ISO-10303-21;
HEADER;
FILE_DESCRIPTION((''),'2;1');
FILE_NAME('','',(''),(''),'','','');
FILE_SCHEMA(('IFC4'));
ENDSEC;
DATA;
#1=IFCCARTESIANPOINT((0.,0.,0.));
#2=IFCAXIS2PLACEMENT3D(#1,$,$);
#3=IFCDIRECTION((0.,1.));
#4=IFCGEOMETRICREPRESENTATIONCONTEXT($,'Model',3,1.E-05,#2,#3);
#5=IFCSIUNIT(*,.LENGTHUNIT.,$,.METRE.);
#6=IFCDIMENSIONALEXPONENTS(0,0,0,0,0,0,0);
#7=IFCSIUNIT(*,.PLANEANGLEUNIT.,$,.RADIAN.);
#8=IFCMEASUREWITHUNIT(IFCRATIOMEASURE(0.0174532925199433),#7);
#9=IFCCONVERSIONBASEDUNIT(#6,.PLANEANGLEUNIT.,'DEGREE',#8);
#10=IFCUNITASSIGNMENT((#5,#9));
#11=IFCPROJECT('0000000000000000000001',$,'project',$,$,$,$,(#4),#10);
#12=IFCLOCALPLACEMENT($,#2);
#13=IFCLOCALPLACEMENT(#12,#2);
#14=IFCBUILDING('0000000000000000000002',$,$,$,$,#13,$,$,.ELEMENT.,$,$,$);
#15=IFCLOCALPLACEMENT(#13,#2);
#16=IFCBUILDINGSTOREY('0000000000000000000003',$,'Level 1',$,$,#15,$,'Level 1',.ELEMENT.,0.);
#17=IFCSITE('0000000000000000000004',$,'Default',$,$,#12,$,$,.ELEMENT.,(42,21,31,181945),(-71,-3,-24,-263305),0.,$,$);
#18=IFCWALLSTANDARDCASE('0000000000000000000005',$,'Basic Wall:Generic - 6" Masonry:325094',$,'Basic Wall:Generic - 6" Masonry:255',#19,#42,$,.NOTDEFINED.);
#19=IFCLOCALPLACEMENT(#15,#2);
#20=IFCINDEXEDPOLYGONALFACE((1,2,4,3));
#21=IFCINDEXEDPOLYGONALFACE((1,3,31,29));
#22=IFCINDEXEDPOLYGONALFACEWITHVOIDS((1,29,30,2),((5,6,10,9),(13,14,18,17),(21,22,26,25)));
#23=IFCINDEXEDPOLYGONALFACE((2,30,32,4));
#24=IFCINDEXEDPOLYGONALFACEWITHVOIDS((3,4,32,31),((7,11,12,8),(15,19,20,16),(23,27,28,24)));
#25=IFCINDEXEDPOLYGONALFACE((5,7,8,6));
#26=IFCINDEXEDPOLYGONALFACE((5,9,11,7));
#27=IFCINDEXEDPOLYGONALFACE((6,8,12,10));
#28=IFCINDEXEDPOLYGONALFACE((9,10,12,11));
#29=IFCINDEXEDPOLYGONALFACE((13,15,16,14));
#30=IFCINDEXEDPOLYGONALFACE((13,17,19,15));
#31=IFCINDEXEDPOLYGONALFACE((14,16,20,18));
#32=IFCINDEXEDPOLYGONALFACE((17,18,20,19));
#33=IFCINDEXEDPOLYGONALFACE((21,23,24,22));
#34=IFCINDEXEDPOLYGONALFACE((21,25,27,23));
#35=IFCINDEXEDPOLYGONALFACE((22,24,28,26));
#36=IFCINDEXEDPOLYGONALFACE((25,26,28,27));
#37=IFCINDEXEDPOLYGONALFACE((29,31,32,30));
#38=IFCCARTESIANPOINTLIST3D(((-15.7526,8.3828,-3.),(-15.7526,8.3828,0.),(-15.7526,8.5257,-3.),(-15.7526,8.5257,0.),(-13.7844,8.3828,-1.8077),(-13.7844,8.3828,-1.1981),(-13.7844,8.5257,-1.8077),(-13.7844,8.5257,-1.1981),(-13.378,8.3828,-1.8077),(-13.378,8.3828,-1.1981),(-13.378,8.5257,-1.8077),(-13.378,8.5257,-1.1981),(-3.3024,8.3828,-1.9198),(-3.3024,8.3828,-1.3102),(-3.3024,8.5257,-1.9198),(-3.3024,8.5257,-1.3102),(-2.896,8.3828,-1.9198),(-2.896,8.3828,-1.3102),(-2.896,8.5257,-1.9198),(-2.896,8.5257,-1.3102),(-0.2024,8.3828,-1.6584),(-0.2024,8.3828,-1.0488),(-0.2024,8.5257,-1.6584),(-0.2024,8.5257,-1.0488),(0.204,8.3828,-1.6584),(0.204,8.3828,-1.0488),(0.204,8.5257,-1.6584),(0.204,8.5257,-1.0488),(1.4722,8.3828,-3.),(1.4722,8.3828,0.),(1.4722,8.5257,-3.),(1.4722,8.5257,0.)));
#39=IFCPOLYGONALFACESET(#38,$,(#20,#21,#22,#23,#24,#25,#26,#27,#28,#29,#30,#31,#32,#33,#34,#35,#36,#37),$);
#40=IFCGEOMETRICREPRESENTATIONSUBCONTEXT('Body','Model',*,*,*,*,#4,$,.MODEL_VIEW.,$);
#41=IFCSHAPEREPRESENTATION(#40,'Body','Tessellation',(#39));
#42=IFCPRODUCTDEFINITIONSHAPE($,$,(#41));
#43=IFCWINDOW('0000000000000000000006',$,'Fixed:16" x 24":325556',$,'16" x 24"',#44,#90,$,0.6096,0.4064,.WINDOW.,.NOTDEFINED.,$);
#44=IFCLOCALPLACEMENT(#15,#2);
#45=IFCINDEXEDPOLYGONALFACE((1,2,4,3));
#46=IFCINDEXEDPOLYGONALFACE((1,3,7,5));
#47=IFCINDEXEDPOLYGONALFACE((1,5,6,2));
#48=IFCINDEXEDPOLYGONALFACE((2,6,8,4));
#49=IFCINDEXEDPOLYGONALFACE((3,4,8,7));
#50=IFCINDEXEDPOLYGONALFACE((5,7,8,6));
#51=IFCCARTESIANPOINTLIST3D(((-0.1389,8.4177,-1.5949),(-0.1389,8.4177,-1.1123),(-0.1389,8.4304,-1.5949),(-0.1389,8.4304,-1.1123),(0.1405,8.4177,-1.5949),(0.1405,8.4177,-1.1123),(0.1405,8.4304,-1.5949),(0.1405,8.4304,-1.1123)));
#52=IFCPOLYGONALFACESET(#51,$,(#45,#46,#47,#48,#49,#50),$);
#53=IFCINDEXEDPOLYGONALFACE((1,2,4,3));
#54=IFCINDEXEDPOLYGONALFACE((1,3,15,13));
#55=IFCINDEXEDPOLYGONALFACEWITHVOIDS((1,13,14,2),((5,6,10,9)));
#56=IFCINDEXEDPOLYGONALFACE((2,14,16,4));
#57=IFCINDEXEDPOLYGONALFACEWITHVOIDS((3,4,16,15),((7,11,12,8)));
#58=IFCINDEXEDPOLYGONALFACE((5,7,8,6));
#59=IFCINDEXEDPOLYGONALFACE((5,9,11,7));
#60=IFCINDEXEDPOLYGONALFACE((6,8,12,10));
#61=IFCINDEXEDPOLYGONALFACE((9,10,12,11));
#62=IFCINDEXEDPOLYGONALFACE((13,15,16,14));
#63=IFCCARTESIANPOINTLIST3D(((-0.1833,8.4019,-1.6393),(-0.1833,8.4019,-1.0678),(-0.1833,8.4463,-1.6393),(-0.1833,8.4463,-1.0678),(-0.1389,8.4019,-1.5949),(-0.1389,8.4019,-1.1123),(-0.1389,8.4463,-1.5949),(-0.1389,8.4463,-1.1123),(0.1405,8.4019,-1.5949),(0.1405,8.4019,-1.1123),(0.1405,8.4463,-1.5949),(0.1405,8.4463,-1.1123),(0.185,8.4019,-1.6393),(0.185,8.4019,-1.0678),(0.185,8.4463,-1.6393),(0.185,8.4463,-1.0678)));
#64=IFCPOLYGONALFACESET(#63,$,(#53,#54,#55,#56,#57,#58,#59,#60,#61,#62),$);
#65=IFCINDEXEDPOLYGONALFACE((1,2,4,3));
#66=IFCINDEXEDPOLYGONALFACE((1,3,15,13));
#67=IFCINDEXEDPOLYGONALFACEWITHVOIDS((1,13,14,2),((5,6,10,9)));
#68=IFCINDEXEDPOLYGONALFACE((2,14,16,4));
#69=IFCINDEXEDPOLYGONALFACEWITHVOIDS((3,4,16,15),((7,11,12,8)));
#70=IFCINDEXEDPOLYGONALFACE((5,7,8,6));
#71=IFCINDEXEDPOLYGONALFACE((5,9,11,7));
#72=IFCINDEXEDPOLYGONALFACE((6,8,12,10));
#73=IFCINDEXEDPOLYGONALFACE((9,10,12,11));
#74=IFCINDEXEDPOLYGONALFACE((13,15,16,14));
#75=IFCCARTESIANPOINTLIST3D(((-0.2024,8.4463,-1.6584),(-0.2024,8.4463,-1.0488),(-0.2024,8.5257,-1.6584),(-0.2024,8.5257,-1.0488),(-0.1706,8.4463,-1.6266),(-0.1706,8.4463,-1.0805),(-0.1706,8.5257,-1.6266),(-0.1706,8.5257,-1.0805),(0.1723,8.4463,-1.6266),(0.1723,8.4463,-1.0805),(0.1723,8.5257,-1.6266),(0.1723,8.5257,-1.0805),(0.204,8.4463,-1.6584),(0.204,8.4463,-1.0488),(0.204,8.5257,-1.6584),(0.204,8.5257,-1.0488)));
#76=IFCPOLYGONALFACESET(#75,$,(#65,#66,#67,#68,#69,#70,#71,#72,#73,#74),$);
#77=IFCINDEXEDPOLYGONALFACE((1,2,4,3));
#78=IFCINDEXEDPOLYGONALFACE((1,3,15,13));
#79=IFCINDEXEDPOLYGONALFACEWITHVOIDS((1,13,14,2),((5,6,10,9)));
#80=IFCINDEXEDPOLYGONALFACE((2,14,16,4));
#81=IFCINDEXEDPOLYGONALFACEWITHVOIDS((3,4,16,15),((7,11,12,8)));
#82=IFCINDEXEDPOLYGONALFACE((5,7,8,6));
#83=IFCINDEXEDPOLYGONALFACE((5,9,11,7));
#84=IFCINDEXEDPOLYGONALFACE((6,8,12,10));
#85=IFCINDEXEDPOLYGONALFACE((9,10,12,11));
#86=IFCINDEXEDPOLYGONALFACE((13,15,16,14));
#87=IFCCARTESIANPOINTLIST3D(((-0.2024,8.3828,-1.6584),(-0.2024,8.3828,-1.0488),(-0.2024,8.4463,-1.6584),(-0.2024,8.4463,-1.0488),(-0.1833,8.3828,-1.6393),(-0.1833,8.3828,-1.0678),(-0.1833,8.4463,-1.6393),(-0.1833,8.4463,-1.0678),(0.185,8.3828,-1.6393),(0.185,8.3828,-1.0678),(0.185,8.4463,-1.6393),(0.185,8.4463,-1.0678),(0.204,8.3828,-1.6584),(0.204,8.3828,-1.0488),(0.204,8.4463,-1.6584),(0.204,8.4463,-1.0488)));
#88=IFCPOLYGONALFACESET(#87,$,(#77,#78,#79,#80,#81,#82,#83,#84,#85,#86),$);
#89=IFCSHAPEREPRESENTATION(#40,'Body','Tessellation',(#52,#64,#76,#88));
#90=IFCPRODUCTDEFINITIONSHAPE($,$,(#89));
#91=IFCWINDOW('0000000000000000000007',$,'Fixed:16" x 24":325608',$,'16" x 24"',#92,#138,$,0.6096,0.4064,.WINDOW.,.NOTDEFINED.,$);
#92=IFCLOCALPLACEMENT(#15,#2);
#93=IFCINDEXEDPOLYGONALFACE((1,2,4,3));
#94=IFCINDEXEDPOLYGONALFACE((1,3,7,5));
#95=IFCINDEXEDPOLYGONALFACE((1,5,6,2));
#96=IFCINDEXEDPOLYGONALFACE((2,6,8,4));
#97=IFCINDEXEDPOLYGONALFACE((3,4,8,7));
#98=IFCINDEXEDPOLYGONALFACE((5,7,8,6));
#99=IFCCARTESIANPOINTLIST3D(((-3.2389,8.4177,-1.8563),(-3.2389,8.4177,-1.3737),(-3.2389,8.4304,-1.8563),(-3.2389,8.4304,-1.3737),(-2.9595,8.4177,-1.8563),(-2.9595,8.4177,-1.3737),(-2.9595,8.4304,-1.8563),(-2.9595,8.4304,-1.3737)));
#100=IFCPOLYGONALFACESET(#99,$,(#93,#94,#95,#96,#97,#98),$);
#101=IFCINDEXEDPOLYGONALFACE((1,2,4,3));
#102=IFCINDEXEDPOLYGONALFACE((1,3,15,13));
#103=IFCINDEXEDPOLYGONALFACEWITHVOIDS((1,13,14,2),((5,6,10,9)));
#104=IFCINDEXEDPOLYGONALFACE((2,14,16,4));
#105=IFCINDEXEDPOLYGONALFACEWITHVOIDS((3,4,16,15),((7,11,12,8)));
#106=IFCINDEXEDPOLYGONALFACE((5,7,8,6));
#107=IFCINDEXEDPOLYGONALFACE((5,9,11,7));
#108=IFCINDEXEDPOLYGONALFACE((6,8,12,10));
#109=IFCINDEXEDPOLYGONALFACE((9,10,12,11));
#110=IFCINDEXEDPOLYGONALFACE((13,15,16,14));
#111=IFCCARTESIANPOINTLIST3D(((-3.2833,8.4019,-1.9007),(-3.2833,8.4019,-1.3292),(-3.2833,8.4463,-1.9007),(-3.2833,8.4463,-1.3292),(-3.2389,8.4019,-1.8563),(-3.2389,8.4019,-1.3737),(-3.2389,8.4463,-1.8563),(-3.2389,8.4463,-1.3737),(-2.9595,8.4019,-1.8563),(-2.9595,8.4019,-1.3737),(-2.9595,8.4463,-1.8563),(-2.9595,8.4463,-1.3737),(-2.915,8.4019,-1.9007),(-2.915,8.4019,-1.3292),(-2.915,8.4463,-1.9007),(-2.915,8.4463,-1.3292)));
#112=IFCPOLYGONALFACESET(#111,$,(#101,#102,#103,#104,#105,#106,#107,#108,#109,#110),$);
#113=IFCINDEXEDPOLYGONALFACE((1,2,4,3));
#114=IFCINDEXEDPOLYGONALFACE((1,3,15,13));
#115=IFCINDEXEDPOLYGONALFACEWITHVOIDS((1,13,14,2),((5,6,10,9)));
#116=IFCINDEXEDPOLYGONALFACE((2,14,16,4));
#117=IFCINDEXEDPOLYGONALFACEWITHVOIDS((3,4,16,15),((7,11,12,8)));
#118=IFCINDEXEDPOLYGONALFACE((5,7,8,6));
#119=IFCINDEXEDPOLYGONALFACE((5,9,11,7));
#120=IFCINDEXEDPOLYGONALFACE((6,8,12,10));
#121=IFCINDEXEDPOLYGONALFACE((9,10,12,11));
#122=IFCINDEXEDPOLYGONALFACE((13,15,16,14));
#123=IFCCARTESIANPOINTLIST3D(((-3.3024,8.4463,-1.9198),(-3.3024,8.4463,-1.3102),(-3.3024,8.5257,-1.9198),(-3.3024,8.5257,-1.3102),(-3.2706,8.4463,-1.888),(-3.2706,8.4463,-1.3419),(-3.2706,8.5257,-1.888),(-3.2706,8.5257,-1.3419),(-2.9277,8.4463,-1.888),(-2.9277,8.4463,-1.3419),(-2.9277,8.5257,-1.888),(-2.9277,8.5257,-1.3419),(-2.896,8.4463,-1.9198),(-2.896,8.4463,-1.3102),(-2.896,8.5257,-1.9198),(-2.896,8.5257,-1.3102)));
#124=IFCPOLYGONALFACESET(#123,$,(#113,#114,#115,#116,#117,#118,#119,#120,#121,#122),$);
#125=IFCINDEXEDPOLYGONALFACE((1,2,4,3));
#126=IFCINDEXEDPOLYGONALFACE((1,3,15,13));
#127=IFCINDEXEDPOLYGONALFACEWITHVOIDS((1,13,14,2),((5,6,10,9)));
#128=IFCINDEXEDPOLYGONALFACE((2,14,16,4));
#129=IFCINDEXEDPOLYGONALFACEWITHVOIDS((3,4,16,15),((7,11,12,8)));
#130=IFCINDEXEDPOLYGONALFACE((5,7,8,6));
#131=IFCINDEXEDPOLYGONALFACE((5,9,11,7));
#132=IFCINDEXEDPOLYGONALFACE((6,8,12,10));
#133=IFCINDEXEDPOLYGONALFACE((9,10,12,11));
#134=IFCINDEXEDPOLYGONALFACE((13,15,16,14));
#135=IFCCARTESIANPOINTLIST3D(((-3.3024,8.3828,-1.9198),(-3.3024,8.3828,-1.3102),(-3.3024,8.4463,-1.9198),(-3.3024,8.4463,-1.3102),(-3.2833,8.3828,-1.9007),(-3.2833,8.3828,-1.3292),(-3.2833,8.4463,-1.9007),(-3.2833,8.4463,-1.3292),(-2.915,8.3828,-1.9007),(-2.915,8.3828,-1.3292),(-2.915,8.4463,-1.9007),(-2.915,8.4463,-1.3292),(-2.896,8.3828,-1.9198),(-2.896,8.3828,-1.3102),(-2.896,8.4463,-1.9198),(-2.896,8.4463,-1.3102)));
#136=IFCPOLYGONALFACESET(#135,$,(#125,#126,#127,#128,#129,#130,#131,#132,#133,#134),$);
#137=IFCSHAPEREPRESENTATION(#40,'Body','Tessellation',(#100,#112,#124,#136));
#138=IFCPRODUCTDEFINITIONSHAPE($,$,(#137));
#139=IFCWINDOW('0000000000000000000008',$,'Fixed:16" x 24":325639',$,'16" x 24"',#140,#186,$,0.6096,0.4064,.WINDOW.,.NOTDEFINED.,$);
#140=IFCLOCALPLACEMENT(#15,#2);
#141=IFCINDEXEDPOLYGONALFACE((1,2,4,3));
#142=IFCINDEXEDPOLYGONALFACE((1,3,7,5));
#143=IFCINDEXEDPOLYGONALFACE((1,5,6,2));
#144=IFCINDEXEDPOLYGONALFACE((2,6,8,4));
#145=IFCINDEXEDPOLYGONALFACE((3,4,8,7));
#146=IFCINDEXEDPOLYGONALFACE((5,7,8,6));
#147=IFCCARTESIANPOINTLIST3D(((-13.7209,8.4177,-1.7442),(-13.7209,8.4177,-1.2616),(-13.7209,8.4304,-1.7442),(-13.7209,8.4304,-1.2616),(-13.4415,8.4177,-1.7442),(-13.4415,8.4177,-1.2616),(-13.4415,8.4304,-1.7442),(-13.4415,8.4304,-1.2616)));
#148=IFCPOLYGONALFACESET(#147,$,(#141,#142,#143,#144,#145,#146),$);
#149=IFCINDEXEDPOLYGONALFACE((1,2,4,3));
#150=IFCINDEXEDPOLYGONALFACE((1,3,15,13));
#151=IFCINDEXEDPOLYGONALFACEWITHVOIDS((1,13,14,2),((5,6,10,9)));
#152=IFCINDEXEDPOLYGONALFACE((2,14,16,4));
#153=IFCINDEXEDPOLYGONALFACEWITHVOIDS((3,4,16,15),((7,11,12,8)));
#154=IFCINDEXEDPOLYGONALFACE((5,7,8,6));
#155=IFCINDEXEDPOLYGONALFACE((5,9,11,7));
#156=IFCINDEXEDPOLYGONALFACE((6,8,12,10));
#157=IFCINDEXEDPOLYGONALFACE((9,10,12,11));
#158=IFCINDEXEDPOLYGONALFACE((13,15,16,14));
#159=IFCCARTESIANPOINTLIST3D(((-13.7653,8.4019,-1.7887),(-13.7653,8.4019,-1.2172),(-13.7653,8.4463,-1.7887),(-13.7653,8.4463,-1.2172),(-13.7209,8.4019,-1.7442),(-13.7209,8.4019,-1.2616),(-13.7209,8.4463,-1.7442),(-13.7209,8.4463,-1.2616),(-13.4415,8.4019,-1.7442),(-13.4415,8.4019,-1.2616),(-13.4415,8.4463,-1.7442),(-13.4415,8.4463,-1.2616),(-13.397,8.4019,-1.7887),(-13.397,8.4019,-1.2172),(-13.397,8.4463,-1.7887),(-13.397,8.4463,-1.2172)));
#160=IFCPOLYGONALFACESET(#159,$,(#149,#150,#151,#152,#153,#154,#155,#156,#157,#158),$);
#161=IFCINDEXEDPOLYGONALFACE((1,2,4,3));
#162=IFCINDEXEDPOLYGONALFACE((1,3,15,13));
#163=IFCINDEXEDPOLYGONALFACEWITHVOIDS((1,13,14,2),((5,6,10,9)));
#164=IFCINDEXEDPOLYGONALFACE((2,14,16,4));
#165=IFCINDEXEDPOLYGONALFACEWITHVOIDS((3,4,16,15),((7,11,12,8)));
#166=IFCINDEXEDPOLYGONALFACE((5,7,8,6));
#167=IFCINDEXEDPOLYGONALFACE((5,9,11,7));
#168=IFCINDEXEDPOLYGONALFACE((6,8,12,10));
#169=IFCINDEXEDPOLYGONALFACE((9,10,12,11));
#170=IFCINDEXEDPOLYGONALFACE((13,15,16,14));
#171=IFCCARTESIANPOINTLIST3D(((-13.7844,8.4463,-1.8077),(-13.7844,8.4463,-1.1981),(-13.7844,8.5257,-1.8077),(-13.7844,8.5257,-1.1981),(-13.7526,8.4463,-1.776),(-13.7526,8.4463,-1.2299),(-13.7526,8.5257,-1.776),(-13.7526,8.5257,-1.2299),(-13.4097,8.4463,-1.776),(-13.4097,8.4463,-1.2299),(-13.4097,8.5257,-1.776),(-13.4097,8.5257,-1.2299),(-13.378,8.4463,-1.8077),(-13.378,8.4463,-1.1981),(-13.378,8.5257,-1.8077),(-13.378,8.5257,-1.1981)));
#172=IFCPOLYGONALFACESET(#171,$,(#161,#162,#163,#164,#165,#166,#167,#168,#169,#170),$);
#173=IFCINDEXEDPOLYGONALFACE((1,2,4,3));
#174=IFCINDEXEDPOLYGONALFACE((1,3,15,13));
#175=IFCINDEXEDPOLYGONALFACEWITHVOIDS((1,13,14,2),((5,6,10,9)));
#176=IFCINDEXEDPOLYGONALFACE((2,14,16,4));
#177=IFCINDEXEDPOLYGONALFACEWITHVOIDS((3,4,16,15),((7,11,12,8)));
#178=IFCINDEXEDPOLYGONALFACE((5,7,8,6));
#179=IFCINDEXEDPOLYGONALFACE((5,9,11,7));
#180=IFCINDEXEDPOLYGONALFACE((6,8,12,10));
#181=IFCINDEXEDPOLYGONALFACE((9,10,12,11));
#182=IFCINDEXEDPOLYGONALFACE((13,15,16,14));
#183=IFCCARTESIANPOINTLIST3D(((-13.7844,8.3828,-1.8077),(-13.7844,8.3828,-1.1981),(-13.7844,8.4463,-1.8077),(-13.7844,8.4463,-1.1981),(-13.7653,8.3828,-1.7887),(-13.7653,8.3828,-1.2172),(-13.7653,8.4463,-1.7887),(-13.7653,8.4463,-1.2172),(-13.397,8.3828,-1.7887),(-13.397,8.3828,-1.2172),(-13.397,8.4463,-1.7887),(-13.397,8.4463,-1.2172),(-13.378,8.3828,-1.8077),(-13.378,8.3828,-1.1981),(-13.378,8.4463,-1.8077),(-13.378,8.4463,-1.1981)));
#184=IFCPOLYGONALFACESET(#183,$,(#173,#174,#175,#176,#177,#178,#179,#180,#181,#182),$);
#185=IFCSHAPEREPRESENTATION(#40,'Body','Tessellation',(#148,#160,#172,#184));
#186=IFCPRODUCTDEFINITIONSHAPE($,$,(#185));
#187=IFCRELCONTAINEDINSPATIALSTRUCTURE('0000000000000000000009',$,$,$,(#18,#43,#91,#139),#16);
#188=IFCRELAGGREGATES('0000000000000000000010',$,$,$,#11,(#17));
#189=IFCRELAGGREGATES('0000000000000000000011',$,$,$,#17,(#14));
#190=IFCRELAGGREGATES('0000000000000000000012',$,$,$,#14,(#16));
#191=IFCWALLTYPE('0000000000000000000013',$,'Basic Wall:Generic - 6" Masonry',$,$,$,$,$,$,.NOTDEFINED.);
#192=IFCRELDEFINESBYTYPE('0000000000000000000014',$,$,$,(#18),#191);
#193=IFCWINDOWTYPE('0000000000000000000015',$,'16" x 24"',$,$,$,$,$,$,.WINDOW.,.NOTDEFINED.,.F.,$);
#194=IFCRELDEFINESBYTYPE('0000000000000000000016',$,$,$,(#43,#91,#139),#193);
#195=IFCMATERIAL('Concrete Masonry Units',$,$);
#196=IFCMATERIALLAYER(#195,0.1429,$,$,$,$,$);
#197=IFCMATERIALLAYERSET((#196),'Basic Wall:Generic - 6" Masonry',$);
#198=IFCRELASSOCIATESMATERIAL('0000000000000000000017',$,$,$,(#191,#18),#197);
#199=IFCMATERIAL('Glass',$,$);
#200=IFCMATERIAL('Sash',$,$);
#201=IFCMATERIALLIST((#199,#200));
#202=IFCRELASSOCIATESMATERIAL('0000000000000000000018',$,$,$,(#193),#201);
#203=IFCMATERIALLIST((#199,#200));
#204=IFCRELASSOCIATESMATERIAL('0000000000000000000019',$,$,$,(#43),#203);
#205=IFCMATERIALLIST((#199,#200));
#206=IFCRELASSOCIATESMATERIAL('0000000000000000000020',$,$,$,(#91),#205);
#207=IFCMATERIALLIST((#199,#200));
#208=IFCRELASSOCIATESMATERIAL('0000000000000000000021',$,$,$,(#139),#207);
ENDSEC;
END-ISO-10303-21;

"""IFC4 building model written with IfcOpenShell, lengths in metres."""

from ifc_helpers import new_model, entity, si_unit, converted_unit, direction, frame, frame_2d, origin, place, context, subcontext, project, spatial, polyline, rectangle, outline, extrude, source, transform, mapped, material, material_list, layer, layer_set, layer_usage, type_object, type_shapes, element, fill, save


model = new_model("IFC4")

# Units and contexts
model_context = context("Model", 3, precision=1e-05, world=origin(), true_north=direction((0.0, 1.0)))
body_context = subcontext(model_context, "Body", "Model", "MODEL_VIEW")
ifc_project = project(units=[si_unit("LENGTHUNIT", "METRE"), converted_unit("PLANEANGLEUNIT", "DEGREE", entity("IfcRatioMeasure", 0.0174532925199433), si_unit("PLANEANGLEUNIT", "RADIAN"), dimensions=[0, 0, 0, 0, 0, 0, 0])], contexts=[model_context])

# Site, building, storey
site_placement = place(None, origin())
site = spatial("IfcSite", under=ifc_project, at=site_placement, Name="Default", CompositionType="ELEMENT", RefLatitude=(42, 21, 31, 181945), RefLongitude=(-71, -3, -24, -263305), RefElevation=0.0)
building_placement = place(site_placement, origin())
building = spatial("IfcBuilding", under=site, at=building_placement, CompositionType="ELEMENT")
storey_placement = place(building_placement, origin())
storey = spatial("IfcBuildingStorey", under=building, at=storey_placement, Name="Level 1", LongName="Level 1", CompositionType="ELEMENT", Elevation=0.0)

# Wall, openings, windows
ifc_material_1 = material(Name="Concrete Masonry Units")
ifc_layer = layer(ifc_material_1, 0.1429)
ifc_layer_set = layer_set([ifc_layer], Name="Basic Wall:Generic - 6\" Masonry")
ifc_layer_usage_1 = layer_usage(ifc_layer_set, "AXIS2", "NEGATIVE", 0.0714)
wall_type = type_object("IfcWallType", Name="Basic Wall:Generic - 6\" Masonry", PredefinedType="NOTDEFINED", material=ifc_layer_set)
wall_1_placement = place(storey_placement, frame((-15.7526, 8.4542, -3.0)))
wall_1 = element("IfcWallStandardCase", 1, at=wall_1_placement, inside=storey, type_object=wall_type, material=ifc_layer_usage_1, Name="Basic Wall:Generic - 6\" Masonry:325094", ObjectType="Basic Wall:Generic - 6\" Masonry:255", PredefinedType="NOTDEFINED", context=body_context, shape_type="SweptSolid", body=[
    extrude(rectangle(XDim=17.2249, YDim=0.1429, at=frame_2d((8.6124, 0.0), x_axis=(-1.0, 0.0))), origin(), (0.0, 0.0, 1.0), 3.0),
])
opening_1_placement = place(wall_1_placement, frame((15.9566, 0.0714, 1.3416)))
opening_1 = element("IfcOpeningElement", 2, at=opening_1_placement, cuts=wall_1, ObjectType="Opening", PredefinedType="OPENING", context=body_context, shape_type="SweptSolid", body=[
    extrude(rectangle(XDim=0.6096, YDim=0.4064, at=frame_2d((0.3048, 0.2032), x_axis=(-1.0, 0.0))), frame((0.0, 0.0, 0.0), z_axis=(0.0, -1.0, 0.0), x_axis=(0.0, 0.0, 1.0)), (0.0, 0.0, 1.0), 0.1429),
])
opening_2_placement = place(wall_1_placement, frame((12.8566, 0.0714, 1.0802)))
opening_2 = element("IfcOpeningElement", 3, at=opening_2_placement, cuts=wall_1, ObjectType="Opening", PredefinedType="OPENING", context=body_context, shape_type="SweptSolid", body=[
    extrude(rectangle(XDim=0.6096, YDim=0.4064, at=frame_2d((0.3048, 0.2032), x_axis=(-1.0, 0.0))), frame((0.0, 0.0, 0.0), z_axis=(0.0, -1.0, 0.0), x_axis=(0.0, 0.0, 1.0)), (0.0, 0.0, 1.0), 0.1429),
])
opening_3_placement = place(wall_1_placement, frame((2.3746, 0.0714, 1.1923)))
opening_3 = element("IfcOpeningElement", 4, at=opening_3_placement, cuts=wall_1, ObjectType="Opening", PredefinedType="OPENING", context=body_context, shape_type="SweptSolid", body=[
    extrude(rectangle(XDim=0.6096, YDim=0.4064, at=frame_2d((0.3048, 0.2032), x_axis=(-1.0, 0.0))), frame((0.0, 0.0, 0.0), z_axis=(0.0, -1.0, 0.0), x_axis=(0.0, 0.0, 1.0)), (0.0, 0.0, 1.0), 0.1429),
])
ifc_material_2 = material(Name="Glass")
ifc_material_3 = material(Name="Sash")
ifc_material_list_1 = material_list([ifc_material_2, ifc_material_3])
ifc_material_list_2 = material_list([ifc_material_2, ifc_material_3])
window_type = type_object("IfcWindowType", Name="16\" x 24\"", ParameterTakesPrecedence=False, PartitioningType="NOTDEFINED", PredefinedType="WINDOW", material=ifc_material_list_2)
shared_shape = source(origin(), body_context, "Body", "SweptSolid", [
    extrude(rectangle(XDim=0.0127, YDim=0.2794, at=frame_2d((0.0, 0.0), x_axis=(1.0, 0.0))), frame((0.2032, 0.1016, 0.0635), z_axis=(0.0, 0.0, 1.0), x_axis=(0.0, 1.0, 0.0)), (0.0, 0.0, 1.0), 0.4826),
    extrude(outline(polyline([(-0.1841, -0.2858), (0.1841, -0.2858), (0.1841, 0.2858), (-0.1841, 0.2858), (-0.1841, -0.2858)]), holes=[polyline([(-0.1397, -0.2413), (-0.1397, 0.2413), (0.1397, 0.2413), (0.1397, -0.2413), (-0.1397, -0.2413)])]), frame((0.2032, 0.0794, 0.3048), z_axis=(0.0, 1.0, 0.0), x_axis=(1.0, 0.0, 0.0)), (0.0, 0.0, 1.0), 0.0445),
    extrude(outline(polyline([(-0.2032, -0.3048), (0.2032, -0.3048), (0.2032, 0.3048), (-0.2032, 0.3048), (-0.2032, -0.3048)]), holes=[polyline([(-0.1715, -0.273), (-0.1715, 0.2731), (0.1714, 0.2731), (0.1714, -0.273), (-0.1715, -0.273)])]), frame((0.2032, 0.0, 0.3048), z_axis=(0.0, 1.0, 0.0), x_axis=(1.0, 0.0, 0.0)), (0.0, 0.0, 1.0), 0.0794),
    extrude(outline(polyline([(-0.3048, -0.2032), (0.3048, -0.2032), (0.3048, 0.2032), (-0.3048, 0.2032), (-0.3048, -0.2032)]), holes=[polyline([(-0.2857, -0.1841), (-0.2857, 0.1842), (0.2858, 0.1842), (0.2858, -0.1841), (-0.2857, -0.1841)])]), frame((0.2032, 0.0794, 0.3048), z_axis=(0.0, 1.0, 0.0), x_axis=(0.0, 0.0, -1.0)), (0.0, 0.0, 1.0), 0.0635),
])
type_shapes(window_type, [shared_shape])
window_1_placement = place(opening_1_placement, frame((0.0, 0.0, 0.0), z_axis=(0.0, 0.0, 1.0), x_axis=(-1.0, 0.0, 0.0)))
window_1 = element("IfcWindow", 5, at=window_1_placement, inside=storey, type_object=window_type, material=ifc_material_list_1, Name="Fixed:16\" x 24\":325556", ObjectType="16\" x 24\"", OverallHeight=0.6096, OverallWidth=0.4064, PartitioningType="NOTDEFINED", PredefinedType="WINDOW", context=body_context, shape_type="MappedRepresentation", body=[
    mapped(shared_shape, transform((0.0, 0.0, 0.0), scale=1.0)),
])
fill(opening_1, window_1)
ifc_material_list_3 = material_list([ifc_material_2, ifc_material_3])
window_2_placement = place(opening_2_placement, frame((0.0, 0.0, 0.0), z_axis=(0.0, 0.0, 1.0), x_axis=(-1.0, 0.0, 0.0)))
window_2 = element("IfcWindow", 6, at=window_2_placement, inside=storey, type_object=window_type, material=ifc_material_list_3, Name="Fixed:16\" x 24\":325608", ObjectType="16\" x 24\"", OverallHeight=0.6096, OverallWidth=0.4064, PartitioningType="NOTDEFINED", PredefinedType="WINDOW", context=body_context, shape_type="MappedRepresentation", body=[
    mapped(shared_shape, transform((0.0, 0.0, 0.0), scale=1.0)),
])
fill(opening_2, window_2)
ifc_material_list_4 = material_list([ifc_material_2, ifc_material_3])
window_3_placement = place(opening_3_placement, frame((0.0, 0.0, 0.0), z_axis=(0.0, 0.0, 1.0), x_axis=(-1.0, 0.0, 0.0)))
window_3 = element("IfcWindow", 7, at=window_3_placement, inside=storey, type_object=window_type, material=ifc_material_list_4, Name="Fixed:16\" x 24\":325639", ObjectType="16\" x 24\"", OverallHeight=0.6096, OverallWidth=0.4064, PartitioningType="NOTDEFINED", PredefinedType="WINDOW", context=body_context, shape_type="MappedRepresentation", body=[
    mapped(shared_shape, transform((0.0, 0.0, 0.0), scale=1.0)),
])
fill(opening_3, window_3)

save(model, "model.ifc")
